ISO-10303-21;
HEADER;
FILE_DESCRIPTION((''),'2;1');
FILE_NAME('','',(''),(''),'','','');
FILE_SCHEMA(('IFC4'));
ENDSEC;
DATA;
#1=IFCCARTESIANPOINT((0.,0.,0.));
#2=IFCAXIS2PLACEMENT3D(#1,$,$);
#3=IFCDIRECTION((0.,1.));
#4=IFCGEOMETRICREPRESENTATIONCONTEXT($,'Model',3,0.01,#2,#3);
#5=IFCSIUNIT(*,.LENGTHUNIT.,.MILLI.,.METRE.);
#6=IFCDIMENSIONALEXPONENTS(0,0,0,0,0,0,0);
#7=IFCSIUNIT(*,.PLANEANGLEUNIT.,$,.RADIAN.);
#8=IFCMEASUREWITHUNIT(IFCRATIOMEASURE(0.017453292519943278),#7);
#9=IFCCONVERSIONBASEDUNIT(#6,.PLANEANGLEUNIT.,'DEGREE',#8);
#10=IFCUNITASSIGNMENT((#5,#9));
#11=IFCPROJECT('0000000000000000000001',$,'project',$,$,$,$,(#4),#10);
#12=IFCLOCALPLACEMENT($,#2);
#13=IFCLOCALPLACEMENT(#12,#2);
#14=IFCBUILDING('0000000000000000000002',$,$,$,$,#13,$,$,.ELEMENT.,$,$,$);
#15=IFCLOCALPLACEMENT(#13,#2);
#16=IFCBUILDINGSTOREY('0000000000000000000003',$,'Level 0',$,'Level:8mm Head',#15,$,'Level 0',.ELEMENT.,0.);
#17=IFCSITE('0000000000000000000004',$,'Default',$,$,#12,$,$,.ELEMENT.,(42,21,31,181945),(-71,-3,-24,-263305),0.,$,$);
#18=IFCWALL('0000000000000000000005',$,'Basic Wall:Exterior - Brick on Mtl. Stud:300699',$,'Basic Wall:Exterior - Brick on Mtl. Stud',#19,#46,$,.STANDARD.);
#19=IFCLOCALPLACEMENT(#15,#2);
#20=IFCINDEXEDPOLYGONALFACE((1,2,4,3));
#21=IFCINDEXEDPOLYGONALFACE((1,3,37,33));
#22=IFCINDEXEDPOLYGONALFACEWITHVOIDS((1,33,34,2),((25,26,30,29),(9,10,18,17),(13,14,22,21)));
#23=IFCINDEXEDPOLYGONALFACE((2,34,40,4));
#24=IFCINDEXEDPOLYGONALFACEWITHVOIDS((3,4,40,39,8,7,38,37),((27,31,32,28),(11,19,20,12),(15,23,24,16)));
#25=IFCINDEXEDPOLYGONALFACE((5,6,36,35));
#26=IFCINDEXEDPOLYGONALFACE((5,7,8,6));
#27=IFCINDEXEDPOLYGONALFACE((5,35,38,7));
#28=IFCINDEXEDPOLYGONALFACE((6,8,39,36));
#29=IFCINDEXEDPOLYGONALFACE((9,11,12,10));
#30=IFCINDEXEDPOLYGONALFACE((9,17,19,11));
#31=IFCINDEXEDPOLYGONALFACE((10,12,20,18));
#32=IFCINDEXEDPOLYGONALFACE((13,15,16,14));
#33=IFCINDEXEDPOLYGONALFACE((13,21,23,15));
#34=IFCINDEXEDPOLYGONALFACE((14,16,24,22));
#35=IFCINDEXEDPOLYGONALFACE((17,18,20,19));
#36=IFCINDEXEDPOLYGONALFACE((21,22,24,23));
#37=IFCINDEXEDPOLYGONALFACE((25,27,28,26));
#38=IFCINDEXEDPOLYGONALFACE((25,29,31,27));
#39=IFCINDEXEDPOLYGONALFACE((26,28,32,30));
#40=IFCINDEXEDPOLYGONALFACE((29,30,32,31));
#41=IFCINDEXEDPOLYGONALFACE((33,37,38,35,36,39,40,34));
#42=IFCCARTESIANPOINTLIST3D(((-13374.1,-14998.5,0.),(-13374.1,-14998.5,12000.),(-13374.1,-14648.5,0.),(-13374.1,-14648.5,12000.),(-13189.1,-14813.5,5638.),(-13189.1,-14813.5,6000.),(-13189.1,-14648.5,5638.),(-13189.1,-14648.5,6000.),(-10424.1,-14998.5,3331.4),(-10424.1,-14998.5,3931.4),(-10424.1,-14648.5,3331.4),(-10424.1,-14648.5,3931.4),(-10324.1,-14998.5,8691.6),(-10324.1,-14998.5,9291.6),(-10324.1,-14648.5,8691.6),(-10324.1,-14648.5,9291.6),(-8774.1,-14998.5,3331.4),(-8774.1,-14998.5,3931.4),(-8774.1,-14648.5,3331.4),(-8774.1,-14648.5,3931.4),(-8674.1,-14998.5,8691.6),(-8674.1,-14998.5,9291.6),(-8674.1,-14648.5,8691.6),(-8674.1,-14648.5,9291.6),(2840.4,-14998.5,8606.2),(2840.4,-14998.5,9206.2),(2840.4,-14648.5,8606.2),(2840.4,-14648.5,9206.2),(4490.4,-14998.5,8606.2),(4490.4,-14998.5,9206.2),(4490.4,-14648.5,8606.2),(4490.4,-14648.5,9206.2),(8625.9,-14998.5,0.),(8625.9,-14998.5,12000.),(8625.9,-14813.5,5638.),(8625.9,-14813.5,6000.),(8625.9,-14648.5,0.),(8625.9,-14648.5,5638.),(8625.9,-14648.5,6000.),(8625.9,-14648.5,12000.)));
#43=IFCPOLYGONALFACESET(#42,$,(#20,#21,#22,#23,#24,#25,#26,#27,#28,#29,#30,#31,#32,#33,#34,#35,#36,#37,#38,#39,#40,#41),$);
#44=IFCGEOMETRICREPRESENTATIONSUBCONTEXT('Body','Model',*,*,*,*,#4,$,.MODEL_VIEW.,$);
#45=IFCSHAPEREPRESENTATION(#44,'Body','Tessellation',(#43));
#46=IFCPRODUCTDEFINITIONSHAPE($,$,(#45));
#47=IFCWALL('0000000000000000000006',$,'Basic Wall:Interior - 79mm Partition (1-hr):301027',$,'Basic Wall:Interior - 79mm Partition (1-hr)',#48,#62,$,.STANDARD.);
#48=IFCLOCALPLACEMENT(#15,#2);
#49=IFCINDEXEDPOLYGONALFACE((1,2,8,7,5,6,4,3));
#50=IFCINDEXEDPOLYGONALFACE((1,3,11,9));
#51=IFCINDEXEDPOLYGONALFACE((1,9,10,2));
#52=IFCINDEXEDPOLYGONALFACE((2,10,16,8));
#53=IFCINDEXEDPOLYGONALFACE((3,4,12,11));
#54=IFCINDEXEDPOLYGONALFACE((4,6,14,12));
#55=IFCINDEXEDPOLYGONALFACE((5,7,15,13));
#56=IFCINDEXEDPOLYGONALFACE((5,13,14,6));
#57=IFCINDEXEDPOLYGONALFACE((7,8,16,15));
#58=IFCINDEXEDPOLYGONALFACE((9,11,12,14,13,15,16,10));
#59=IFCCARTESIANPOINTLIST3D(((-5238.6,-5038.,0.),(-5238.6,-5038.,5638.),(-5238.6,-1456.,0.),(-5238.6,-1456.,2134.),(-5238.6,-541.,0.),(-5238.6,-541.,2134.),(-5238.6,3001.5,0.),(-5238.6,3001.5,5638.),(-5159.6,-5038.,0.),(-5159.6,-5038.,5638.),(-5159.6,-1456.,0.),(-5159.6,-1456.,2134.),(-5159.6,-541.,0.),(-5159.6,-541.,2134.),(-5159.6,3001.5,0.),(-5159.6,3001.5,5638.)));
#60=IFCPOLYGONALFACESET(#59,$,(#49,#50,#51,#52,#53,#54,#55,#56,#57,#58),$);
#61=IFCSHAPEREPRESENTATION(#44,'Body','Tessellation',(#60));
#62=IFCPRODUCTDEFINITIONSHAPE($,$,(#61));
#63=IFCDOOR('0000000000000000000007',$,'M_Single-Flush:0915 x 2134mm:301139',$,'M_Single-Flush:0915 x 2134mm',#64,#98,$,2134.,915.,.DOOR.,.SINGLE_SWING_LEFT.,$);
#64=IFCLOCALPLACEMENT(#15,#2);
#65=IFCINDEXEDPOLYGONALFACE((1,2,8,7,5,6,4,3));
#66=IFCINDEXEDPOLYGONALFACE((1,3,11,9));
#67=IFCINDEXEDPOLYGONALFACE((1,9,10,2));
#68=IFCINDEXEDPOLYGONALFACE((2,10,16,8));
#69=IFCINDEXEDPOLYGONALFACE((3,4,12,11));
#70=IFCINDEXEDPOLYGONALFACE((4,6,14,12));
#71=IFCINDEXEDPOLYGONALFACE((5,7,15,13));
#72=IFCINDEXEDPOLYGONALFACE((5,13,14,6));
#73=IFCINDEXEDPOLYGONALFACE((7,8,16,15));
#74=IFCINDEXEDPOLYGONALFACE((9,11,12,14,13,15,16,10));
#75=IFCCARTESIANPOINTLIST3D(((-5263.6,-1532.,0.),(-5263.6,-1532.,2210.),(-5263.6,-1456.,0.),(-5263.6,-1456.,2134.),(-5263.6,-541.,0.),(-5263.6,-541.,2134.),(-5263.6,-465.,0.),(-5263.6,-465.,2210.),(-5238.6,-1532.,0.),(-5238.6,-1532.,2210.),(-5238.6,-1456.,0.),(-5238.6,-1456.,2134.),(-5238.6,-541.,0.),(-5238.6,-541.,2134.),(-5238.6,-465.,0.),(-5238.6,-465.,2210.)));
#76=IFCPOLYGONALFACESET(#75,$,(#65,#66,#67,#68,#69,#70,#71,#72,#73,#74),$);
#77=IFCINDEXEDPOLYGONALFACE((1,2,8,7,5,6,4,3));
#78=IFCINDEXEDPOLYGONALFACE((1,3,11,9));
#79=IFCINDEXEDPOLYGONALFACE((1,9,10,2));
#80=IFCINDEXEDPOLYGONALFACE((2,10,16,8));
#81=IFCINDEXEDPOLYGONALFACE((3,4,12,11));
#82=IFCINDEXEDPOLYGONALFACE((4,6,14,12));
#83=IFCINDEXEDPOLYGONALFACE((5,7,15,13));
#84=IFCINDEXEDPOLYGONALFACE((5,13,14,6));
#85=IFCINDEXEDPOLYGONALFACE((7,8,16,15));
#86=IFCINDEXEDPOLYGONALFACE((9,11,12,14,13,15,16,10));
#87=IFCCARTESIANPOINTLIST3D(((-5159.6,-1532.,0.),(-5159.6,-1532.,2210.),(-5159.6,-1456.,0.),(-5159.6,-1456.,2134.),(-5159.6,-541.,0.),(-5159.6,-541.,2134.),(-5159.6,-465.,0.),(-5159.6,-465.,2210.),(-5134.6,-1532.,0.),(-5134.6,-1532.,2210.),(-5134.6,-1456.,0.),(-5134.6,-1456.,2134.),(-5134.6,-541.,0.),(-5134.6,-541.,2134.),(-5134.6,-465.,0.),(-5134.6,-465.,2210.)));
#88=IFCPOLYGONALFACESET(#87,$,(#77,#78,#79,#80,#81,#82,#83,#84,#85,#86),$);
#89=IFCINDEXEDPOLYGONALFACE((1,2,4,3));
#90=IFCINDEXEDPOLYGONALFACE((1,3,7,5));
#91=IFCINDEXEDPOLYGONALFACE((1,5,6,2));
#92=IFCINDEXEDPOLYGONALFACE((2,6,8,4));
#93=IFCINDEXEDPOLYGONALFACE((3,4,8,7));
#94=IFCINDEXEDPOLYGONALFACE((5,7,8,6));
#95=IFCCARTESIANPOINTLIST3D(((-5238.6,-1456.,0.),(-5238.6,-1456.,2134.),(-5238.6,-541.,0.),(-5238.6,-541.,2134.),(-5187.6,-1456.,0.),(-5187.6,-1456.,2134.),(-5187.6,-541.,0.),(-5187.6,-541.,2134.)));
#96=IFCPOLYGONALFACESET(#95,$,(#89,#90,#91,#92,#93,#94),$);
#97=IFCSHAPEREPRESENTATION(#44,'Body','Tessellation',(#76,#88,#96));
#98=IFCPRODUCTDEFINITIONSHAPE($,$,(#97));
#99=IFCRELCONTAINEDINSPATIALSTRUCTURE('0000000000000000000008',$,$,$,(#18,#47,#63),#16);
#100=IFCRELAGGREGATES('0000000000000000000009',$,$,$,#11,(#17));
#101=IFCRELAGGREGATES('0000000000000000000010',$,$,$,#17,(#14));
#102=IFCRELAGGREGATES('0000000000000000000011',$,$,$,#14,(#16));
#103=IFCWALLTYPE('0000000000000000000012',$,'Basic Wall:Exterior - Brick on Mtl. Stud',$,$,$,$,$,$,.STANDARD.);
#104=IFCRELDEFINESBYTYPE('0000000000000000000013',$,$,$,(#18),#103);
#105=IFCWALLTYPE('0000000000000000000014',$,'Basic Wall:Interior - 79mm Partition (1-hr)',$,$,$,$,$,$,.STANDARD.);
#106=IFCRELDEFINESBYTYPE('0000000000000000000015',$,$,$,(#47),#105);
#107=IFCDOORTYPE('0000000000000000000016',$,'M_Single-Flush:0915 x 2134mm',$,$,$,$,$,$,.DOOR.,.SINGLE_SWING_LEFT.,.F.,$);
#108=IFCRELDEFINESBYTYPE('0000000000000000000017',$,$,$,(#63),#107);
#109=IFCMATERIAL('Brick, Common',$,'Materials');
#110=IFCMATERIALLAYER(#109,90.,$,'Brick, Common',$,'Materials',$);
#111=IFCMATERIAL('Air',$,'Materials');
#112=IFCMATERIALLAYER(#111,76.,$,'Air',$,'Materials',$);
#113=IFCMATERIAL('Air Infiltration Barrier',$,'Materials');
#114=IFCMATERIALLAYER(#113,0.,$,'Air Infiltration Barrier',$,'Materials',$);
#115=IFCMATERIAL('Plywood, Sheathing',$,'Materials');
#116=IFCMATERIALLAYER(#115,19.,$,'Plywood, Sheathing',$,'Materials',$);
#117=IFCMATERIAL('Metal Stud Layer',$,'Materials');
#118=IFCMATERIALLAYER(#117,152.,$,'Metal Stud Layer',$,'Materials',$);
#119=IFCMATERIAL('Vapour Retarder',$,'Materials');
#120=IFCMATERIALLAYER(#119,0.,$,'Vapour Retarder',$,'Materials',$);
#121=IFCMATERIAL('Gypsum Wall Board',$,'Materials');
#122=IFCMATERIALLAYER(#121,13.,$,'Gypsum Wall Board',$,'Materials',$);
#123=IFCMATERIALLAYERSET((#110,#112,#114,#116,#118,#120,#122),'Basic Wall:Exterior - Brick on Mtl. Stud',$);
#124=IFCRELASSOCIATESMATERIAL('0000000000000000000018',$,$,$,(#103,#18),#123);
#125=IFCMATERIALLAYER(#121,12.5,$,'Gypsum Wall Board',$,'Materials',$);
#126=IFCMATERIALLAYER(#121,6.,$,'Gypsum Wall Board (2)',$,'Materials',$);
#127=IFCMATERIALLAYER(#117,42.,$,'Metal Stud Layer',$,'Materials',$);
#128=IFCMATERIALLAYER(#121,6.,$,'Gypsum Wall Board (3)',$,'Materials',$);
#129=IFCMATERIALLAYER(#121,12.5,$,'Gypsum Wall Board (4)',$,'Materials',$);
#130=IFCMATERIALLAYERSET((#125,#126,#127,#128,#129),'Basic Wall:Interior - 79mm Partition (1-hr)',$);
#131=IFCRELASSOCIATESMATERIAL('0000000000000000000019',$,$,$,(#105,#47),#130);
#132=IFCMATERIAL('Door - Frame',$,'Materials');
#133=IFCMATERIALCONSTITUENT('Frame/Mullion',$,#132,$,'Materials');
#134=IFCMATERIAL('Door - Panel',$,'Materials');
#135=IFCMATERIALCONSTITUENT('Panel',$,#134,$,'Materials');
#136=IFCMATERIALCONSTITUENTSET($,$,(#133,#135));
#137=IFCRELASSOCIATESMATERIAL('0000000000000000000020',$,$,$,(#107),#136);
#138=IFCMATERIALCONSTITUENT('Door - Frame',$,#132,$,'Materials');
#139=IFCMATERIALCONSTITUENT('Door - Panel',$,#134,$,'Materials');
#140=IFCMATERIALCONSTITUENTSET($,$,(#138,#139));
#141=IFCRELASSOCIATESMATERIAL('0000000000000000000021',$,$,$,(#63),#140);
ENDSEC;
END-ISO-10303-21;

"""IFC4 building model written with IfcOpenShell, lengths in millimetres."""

from ifc_helpers import new_model, entity, si_unit, converted_unit, direction, frame, frame_2d, origin, origin_2d_with_axis, place, context, subcontext, project, spatial, polyline, rectangle, outline, extrude, clip, bounded_halfspace, source, transform, mapped, material, layer, layer_set, layer_usage, constituent, constituent_set, type_object, type_shapes, element, fill, save


model = new_model("IFC4")

# Units and contexts
model_context = context("Model", 3, precision=0.01, world=origin(), true_north=direction((0.0, 1.0)))
body_context = subcontext(model_context, "Body", "Model", "MODEL_VIEW")
ifc_project = project(units=[si_unit("LENGTHUNIT", "METRE", prefix="MILLI"), converted_unit("PLANEANGLEUNIT", "DEGREE", entity("IfcRatioMeasure", 0.017453292519943278), si_unit("PLANEANGLEUNIT", "RADIAN"), dimensions=[0, 0, 0, 0, 0, 0, 0])], contexts=[model_context])

# Site, building, storey
site_placement = place(None, origin())
site = spatial("IfcSite", under=ifc_project, at=site_placement, Name="Default", CompositionType="ELEMENT", RefLatitude=(42, 21, 31, 181945), RefLongitude=(-71, -3, -24, -263305), RefElevation=0.0)
building_placement = place(site_placement, origin())
building = spatial("IfcBuilding", under=site, at=building_placement, CompositionType="ELEMENT")
storey_placement = place(building_placement, origin())
storey = spatial("IfcBuildingStorey", under=building, at=storey_placement, Name="Level 0", ObjectType="Level:8mm Head", LongName="Level 0", CompositionType="ELEMENT", Elevation=0.0)

# Shared definitions
ifc_material_1 = material(Name="Air", Category="Materials")
ifc_material_2 = material(Name="Air Infiltration Barrier", Category="Materials")
ifc_material_3 = material(Name="Plywood, Sheathing", Category="Materials")
ifc_material_4 = material(Name="Metal Stud Layer", Category="Materials")
ifc_material_5 = material(Name="Vapour Retarder", Category="Materials")
ifc_material_6 = material(Name="Gypsum Wall Board", Category="Materials")

# Shared definitions
ifc_material_7 = material(Name="Brick, Common", Category="Materials")
ifc_layer_1 = layer(ifc_material_7, 90.0, Name="Brick, Common", Category="Materials")
ifc_layer_2 = layer(ifc_material_1, 76.0, Name="Air", Category="Materials")
ifc_layer_3 = layer(ifc_material_2, 0.0, Name="Air Infiltration Barrier", Category="Materials")
ifc_layer_4 = layer(ifc_material_3, 19.0, Name="Plywood, Sheathing", Category="Materials")
ifc_layer_5 = layer(ifc_material_4, 152.0, Name="Metal Stud Layer", Category="Materials")
ifc_layer_6 = layer(ifc_material_5, 0.0, Name="Vapour Retarder", Category="Materials")
ifc_layer_7 = layer(ifc_material_6, 13.0, Name="Gypsum Wall Board", Category="Materials")
ifc_layer_set_1 = layer_set([ifc_layer_1, ifc_layer_2, ifc_layer_3, ifc_layer_4, ifc_layer_5, ifc_layer_6, ifc_layer_7], Name="Basic Wall:Exterior - Brick on Mtl. Stud")
ifc_layer_usage_1 = layer_usage(ifc_layer_set_1, "AXIS2", "NEGATIVE", 175.0)
wall_type_1 = type_object("IfcWallType", Name="Basic Wall:Exterior - Brick on Mtl. Stud", PredefinedType="STANDARD", material=ifc_layer_set_1)
ifc_material_8 = material(Name="Door - Frame", Category="Materials")
ifc_material_9 = material(Name="Door - Panel", Category="Materials")

# Wall, openings
wall_1_placement = place(storey_placement, frame((8625.9, -14823.5, 0.0), z_axis=(0.0, 0.0, 1.0), x_axis=(-1.0, 0.0, 0.0)))
wall_1 = element("IfcWall", 1, at=wall_1_placement, inside=storey, type_object=wall_type_1, material=ifc_layer_usage_1, Name="Basic Wall:Exterior - Brick on Mtl. Stud:300699", ObjectType="Basic Wall:Exterior - Brick on Mtl. Stud", PredefinedType="STANDARD", context=body_context, shape_type="SweptSolid", body=[
    extrude(rectangle(XDim=22000.0, YDim=350.0, at=frame_2d((11000.0, 0.0), x_axis=(-1.0, 0.0))), origin(), (0.0, 0.0, 1.0), 12000.0),
])
opening_1_placement = place(storey_placement, frame((8625.9, -14823.5, 0.0), z_axis=(0.0, 0.0, 1.0), x_axis=(-1.0, 0.0, 0.0)))
element("IfcOpeningElement", 2, at=opening_1_placement, cuts=wall_1, PredefinedType="OPENING", context=body_context, shape_type="SweptSolid", body=[
    extrude(rectangle(XDim=165.0, YDim=21815.0, at=frame_2d((35.4, 82.5), x_axis=(1.0, 0.0))), frame((10990.0, -127.9, 5638.0), z_axis=(0.0, 0.0, 1.0), x_axis=(0.0, 1.0, 0.0)), (0.0, 0.0, 1.0), 362.0),
])
opening_2_placement = place(wall_1_placement, frame((17300.0, -175.0, 8691.6)))
element("IfcOpeningElement", 3, at=opening_2_placement, cuts=wall_1, PredefinedType="OPENING", context=body_context, shape_type="SweptSolid", body=[
    extrude(rectangle(XDim=600.0, YDim=1650.0, at=frame_2d((300.0, 825.0), x_axis=(-1.0, 0.0))), frame((0.0, 0.0, 0.0), z_axis=(0.0, 1.0, 0.0), x_axis=(0.0, 0.0, 1.0)), (0.0, 0.0, 1.0), 350.0),
])
opening_3_placement = place(wall_1_placement, frame((4135.5, -175.0, 8606.2)))
element("IfcOpeningElement", 4, at=opening_3_placement, cuts=wall_1, PredefinedType="OPENING", context=body_context, shape_type="SweptSolid", body=[
    extrude(rectangle(XDim=600.0, YDim=1650.0, at=frame_2d((300.0, 825.0), x_axis=(-1.0, 0.0))), frame((0.0, 0.0, 0.0), z_axis=(0.0, 1.0, 0.0), x_axis=(0.0, 0.0, 1.0)), (0.0, 0.0, 1.0), 350.0),
])
opening_4_placement = place(wall_1_placement, frame((17400.0, -175.0, 3331.4)))
element("IfcOpeningElement", 5, at=opening_4_placement, cuts=wall_1, PredefinedType="OPENING", context=body_context, shape_type="SweptSolid", body=[
    extrude(rectangle(XDim=600.0, YDim=1650.0, at=frame_2d((300.0, 825.0), x_axis=(-1.0, 0.0))), frame((0.0, 0.0, 0.0), z_axis=(0.0, 1.0, 0.0), x_axis=(0.0, 0.0, 1.0)), (0.0, 0.0, 1.0), 350.0),
])

# Wall, opening, door
ifc_layer_8 = layer(ifc_material_6, 12.5, Name="Gypsum Wall Board", Category="Materials")
ifc_layer_9 = layer(ifc_material_6, 6.0, Name="Gypsum Wall Board (2)", Category="Materials")
ifc_layer_10 = layer(ifc_material_4, 42.0, Name="Metal Stud Layer", Category="Materials")
ifc_layer_11 = layer(ifc_material_6, 6.0, Name="Gypsum Wall Board (3)", Category="Materials")
ifc_layer_12 = layer(ifc_material_6, 12.5, Name="Gypsum Wall Board (4)", Category="Materials")
ifc_layer_set_2 = layer_set([ifc_layer_8, ifc_layer_9, ifc_layer_10, ifc_layer_11, ifc_layer_12], Name="Basic Wall:Interior - 79mm Partition (1-hr)")
ifc_layer_usage_2 = layer_usage(ifc_layer_set_2, "AXIS2", "NEGATIVE", 39.5)
wall_type_2 = type_object("IfcWallType", Name="Basic Wall:Interior - 79mm Partition (1-hr)", PredefinedType="STANDARD", material=ifc_layer_set_2)
wall_2_placement = place(storey_placement, frame((-5199.1, 3001.5, 0.0), z_axis=(0.0, 0.0, 1.0), x_axis=(0.0, -1.0, 0.0)))
wall_2 = element("IfcWall", 6, at=wall_2_placement, inside=storey, type_object=wall_type_2, material=ifc_layer_usage_2, Name="Basic Wall:Interior - 79mm Partition (1-hr):301027", ObjectType="Basic Wall:Interior - 79mm Partition (1-hr)", PredefinedType="STANDARD", context=body_context, shape_type="Clipping", body=[
    clip(extrude(rectangle(XDim=8039.5, YDim=79.0, at=frame_2d((4019.8, 0.0), x_axis=(1.0, 0.0))), origin(), (0.0, 0.0, 1.0), 5638.0), bounded_halfspace(frame((0.0, -39.5, 5638.0), z_axis=(0.0, 0.0, -1.0), x_axis=(1.0, 0.0, 0.0)), True, frame((0.0, -39.5, 5638.0)), polyline([(0.0, 0.0), (2450439.6, 0.0), (2450439.6, 24079.2), (2426360.4, 24079.2), (0.0, 24079.2), (0.0, 0.0)]))),
])
opening_5_placement = place(wall_2_placement, frame((4457.5, 39.5, 0.0)))
opening_5 = element("IfcOpeningElement", 7, at=opening_5_placement, cuts=wall_2, PredefinedType="OPENING", context=body_context, shape_type="SweptSolid", body=[
    extrude(rectangle(XDim=915.0, YDim=2134.0, at=frame_2d((1067.0, 457.5), x_axis=(0.0, -1.0))), frame((0.0, 0.0, 0.0), z_axis=(0.0, -1.0, 0.0), x_axis=(0.0, 0.0, 1.0)), (0.0, 0.0, 1.0), 79.0),
])
ifc_constituent_1 = constituent(ifc_material_8, Name="Door - Frame", Category="Materials")
ifc_constituent_2 = constituent(ifc_material_9, Name="Door - Panel", Category="Materials")
ifc_constituent_set_1 = constituent_set(constituents=[ifc_constituent_1, ifc_constituent_2])
ifc_constituent_3 = constituent(ifc_material_8, Name="Frame/Mullion", Category="Materials")
ifc_constituent_4 = constituent(ifc_material_9, Name="Panel", Category="Materials")
ifc_constituent_set_2 = constituent_set(constituents=[ifc_constituent_3, ifc_constituent_4])
door_type_1 = type_object("IfcDoorType", Name="M_Single-Flush:0915 x 2134mm", OperationType="SINGLE_SWING_LEFT", ParameterTakesPrecedence=False, PredefinedType="DOOR", material=ifc_constituent_set_2)
shared_shape_1 = source(origin(), body_context, "Body", "SweptSolid", [
    extrude(outline(polyline([(-533.5, -1124.0), (533.5, -1124.0), (533.5, 1086.0), (457.5, 1086.0), (457.5, -1048.0), (-457.5, -1048.0), (-457.5, 1086.0), (-533.5, 1086.0), (-533.5, -1124.0)])), frame((457.5, 104.0, 1086.0), z_axis=(0.0, -1.0, 0.0), x_axis=(-1.0, 0.0, 0.0)), (0.0, 0.0, 1.0), 25.0),
    extrude(outline(polyline([(-1124.0, -533.5), (1086.0, -533.5), (1086.0, -457.5), (-1048.0, -457.5), (-1048.0, 457.5), (1086.0, 457.5), (1086.0, 533.5), (-1124.0, 533.5), (-1124.0, -533.5)])), frame((457.5, 0.0, 1086.0), z_axis=(0.0, -1.0, 0.0), x_axis=(0.0, 0.0, -1.0)), (0.0, 0.0, 1.0), 25.0),
    extrude(rectangle(XDim=915.0, YDim=51.0, at=origin_2d_with_axis()), frame((457.5, 53.5, 0.0)), (0.0, 0.0, 1.0), 2134.0),
])
type_shapes(door_type_1, [shared_shape_1])
door_1_placement = place(opening_5_placement, frame((0.0, 0.0, 0.0), z_axis=(0.0, 0.0, 1.0), x_axis=(-1.0, 0.0, 0.0)))
door_1 = element("IfcDoor", 8, at=door_1_placement, inside=storey, type_object=door_type_1, material=ifc_constituent_set_1, Name="M_Single-Flush:0915 x 2134mm:301139", ObjectType="M_Single-Flush:0915 x 2134mm", OperationType="SINGLE_SWING_LEFT", OverallHeight=2134.0, OverallWidth=915.0, PredefinedType="DOOR", context=body_context, shape_type="MappedRepresentation", body=[
    mapped(shared_shape_1, transform((0.0, 0.0, 0.0), scale=1.0)),
])
fill(opening_5, door_1)

save(model, "model.ifc")
